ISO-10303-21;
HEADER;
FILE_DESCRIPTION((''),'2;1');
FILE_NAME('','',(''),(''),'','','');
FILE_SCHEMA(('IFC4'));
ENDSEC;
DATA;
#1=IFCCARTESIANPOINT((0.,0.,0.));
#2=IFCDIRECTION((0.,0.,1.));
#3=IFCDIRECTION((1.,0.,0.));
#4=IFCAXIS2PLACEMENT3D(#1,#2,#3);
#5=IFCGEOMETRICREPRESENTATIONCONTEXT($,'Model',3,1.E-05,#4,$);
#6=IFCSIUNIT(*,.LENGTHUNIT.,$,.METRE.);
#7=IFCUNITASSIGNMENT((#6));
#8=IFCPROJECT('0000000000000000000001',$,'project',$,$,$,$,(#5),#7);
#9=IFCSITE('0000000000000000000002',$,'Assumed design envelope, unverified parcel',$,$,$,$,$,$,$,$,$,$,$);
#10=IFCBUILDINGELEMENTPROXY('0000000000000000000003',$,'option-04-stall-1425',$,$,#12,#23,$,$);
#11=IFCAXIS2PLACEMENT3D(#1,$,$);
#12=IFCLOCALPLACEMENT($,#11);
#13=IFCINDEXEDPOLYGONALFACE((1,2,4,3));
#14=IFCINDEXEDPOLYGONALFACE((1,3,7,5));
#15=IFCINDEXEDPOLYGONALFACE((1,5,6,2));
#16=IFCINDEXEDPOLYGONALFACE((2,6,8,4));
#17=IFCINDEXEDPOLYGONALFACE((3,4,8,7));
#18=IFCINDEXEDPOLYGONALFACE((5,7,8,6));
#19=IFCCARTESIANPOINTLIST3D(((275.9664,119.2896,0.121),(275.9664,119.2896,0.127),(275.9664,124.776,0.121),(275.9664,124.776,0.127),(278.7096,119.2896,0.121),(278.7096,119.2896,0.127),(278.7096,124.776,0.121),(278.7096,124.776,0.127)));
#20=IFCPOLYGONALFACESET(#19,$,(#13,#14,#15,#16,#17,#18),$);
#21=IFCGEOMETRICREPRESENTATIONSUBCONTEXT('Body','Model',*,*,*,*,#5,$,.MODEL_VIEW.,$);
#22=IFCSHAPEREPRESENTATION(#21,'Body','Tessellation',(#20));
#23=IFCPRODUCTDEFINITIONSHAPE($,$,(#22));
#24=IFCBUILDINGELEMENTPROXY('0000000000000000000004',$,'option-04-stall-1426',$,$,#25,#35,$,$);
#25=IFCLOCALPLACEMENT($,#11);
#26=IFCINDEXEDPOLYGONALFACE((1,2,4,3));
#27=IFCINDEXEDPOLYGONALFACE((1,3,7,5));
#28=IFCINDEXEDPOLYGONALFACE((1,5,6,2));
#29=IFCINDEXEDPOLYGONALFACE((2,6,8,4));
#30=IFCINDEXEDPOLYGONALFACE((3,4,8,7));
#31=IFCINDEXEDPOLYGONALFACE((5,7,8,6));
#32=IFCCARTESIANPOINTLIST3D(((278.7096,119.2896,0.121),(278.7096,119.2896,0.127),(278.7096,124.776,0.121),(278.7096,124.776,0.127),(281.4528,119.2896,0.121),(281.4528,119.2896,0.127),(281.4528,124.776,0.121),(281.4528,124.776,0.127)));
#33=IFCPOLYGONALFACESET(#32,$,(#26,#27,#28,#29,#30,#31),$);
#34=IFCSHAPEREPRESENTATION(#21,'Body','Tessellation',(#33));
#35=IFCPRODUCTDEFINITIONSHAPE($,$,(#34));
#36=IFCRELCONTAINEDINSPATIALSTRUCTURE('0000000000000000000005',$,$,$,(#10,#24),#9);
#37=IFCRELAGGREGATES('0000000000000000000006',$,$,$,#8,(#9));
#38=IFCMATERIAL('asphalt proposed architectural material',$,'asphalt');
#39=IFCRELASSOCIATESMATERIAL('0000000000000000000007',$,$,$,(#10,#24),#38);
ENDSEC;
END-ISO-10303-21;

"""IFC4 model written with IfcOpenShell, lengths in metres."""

from ifc_helpers import new_model, si_unit, frame, origin_with_axes, place, context, subcontext, project, spatial, rectangle, extrude, material, element, save


model = new_model("IFC4")

# Units and contexts
model_context = context("Model", 3, precision=1e-05, world=origin_with_axes())
body_context = subcontext(model_context, "Body", "Model", "MODEL_VIEW")
ifc_project = project(units=[si_unit("LENGTHUNIT", "METRE")], contexts=[model_context])

# Site
site = spatial("IfcSite", under=ifc_project, Name="Assumed design envelope, unverified parcel")

# Building element proxies
ifc_material = material(Name="asphalt proposed architectural material", Category="asphalt")
for number, where, z_axis, x_axis, name in (
    (1, (277.338, 122.0328, 0.121), (0.0, 0.0, 1.0), (1.0, 0.0, 0.0), "option-04-stall-1425"),
    (2, (280.0812, 122.0328, 0.121), (0.0, 0.0, 1.0), (1.0, 0.0, 0.0), "option-04-stall-1426"),
):
    element("IfcBuildingElementProxy", number, at=place(None, frame(where, z_axis=z_axis, x_axis=x_axis)), inside=site, material=ifc_material, Name=name, context=body_context, shape_type="SweptSolid", body=[
        extrude(rectangle(XDim=2.7432, YDim=5.4864), origin_with_axes(), (0.0, 0.0, 1.0), 0.006),
    ])

save(model, "model.ifc")
